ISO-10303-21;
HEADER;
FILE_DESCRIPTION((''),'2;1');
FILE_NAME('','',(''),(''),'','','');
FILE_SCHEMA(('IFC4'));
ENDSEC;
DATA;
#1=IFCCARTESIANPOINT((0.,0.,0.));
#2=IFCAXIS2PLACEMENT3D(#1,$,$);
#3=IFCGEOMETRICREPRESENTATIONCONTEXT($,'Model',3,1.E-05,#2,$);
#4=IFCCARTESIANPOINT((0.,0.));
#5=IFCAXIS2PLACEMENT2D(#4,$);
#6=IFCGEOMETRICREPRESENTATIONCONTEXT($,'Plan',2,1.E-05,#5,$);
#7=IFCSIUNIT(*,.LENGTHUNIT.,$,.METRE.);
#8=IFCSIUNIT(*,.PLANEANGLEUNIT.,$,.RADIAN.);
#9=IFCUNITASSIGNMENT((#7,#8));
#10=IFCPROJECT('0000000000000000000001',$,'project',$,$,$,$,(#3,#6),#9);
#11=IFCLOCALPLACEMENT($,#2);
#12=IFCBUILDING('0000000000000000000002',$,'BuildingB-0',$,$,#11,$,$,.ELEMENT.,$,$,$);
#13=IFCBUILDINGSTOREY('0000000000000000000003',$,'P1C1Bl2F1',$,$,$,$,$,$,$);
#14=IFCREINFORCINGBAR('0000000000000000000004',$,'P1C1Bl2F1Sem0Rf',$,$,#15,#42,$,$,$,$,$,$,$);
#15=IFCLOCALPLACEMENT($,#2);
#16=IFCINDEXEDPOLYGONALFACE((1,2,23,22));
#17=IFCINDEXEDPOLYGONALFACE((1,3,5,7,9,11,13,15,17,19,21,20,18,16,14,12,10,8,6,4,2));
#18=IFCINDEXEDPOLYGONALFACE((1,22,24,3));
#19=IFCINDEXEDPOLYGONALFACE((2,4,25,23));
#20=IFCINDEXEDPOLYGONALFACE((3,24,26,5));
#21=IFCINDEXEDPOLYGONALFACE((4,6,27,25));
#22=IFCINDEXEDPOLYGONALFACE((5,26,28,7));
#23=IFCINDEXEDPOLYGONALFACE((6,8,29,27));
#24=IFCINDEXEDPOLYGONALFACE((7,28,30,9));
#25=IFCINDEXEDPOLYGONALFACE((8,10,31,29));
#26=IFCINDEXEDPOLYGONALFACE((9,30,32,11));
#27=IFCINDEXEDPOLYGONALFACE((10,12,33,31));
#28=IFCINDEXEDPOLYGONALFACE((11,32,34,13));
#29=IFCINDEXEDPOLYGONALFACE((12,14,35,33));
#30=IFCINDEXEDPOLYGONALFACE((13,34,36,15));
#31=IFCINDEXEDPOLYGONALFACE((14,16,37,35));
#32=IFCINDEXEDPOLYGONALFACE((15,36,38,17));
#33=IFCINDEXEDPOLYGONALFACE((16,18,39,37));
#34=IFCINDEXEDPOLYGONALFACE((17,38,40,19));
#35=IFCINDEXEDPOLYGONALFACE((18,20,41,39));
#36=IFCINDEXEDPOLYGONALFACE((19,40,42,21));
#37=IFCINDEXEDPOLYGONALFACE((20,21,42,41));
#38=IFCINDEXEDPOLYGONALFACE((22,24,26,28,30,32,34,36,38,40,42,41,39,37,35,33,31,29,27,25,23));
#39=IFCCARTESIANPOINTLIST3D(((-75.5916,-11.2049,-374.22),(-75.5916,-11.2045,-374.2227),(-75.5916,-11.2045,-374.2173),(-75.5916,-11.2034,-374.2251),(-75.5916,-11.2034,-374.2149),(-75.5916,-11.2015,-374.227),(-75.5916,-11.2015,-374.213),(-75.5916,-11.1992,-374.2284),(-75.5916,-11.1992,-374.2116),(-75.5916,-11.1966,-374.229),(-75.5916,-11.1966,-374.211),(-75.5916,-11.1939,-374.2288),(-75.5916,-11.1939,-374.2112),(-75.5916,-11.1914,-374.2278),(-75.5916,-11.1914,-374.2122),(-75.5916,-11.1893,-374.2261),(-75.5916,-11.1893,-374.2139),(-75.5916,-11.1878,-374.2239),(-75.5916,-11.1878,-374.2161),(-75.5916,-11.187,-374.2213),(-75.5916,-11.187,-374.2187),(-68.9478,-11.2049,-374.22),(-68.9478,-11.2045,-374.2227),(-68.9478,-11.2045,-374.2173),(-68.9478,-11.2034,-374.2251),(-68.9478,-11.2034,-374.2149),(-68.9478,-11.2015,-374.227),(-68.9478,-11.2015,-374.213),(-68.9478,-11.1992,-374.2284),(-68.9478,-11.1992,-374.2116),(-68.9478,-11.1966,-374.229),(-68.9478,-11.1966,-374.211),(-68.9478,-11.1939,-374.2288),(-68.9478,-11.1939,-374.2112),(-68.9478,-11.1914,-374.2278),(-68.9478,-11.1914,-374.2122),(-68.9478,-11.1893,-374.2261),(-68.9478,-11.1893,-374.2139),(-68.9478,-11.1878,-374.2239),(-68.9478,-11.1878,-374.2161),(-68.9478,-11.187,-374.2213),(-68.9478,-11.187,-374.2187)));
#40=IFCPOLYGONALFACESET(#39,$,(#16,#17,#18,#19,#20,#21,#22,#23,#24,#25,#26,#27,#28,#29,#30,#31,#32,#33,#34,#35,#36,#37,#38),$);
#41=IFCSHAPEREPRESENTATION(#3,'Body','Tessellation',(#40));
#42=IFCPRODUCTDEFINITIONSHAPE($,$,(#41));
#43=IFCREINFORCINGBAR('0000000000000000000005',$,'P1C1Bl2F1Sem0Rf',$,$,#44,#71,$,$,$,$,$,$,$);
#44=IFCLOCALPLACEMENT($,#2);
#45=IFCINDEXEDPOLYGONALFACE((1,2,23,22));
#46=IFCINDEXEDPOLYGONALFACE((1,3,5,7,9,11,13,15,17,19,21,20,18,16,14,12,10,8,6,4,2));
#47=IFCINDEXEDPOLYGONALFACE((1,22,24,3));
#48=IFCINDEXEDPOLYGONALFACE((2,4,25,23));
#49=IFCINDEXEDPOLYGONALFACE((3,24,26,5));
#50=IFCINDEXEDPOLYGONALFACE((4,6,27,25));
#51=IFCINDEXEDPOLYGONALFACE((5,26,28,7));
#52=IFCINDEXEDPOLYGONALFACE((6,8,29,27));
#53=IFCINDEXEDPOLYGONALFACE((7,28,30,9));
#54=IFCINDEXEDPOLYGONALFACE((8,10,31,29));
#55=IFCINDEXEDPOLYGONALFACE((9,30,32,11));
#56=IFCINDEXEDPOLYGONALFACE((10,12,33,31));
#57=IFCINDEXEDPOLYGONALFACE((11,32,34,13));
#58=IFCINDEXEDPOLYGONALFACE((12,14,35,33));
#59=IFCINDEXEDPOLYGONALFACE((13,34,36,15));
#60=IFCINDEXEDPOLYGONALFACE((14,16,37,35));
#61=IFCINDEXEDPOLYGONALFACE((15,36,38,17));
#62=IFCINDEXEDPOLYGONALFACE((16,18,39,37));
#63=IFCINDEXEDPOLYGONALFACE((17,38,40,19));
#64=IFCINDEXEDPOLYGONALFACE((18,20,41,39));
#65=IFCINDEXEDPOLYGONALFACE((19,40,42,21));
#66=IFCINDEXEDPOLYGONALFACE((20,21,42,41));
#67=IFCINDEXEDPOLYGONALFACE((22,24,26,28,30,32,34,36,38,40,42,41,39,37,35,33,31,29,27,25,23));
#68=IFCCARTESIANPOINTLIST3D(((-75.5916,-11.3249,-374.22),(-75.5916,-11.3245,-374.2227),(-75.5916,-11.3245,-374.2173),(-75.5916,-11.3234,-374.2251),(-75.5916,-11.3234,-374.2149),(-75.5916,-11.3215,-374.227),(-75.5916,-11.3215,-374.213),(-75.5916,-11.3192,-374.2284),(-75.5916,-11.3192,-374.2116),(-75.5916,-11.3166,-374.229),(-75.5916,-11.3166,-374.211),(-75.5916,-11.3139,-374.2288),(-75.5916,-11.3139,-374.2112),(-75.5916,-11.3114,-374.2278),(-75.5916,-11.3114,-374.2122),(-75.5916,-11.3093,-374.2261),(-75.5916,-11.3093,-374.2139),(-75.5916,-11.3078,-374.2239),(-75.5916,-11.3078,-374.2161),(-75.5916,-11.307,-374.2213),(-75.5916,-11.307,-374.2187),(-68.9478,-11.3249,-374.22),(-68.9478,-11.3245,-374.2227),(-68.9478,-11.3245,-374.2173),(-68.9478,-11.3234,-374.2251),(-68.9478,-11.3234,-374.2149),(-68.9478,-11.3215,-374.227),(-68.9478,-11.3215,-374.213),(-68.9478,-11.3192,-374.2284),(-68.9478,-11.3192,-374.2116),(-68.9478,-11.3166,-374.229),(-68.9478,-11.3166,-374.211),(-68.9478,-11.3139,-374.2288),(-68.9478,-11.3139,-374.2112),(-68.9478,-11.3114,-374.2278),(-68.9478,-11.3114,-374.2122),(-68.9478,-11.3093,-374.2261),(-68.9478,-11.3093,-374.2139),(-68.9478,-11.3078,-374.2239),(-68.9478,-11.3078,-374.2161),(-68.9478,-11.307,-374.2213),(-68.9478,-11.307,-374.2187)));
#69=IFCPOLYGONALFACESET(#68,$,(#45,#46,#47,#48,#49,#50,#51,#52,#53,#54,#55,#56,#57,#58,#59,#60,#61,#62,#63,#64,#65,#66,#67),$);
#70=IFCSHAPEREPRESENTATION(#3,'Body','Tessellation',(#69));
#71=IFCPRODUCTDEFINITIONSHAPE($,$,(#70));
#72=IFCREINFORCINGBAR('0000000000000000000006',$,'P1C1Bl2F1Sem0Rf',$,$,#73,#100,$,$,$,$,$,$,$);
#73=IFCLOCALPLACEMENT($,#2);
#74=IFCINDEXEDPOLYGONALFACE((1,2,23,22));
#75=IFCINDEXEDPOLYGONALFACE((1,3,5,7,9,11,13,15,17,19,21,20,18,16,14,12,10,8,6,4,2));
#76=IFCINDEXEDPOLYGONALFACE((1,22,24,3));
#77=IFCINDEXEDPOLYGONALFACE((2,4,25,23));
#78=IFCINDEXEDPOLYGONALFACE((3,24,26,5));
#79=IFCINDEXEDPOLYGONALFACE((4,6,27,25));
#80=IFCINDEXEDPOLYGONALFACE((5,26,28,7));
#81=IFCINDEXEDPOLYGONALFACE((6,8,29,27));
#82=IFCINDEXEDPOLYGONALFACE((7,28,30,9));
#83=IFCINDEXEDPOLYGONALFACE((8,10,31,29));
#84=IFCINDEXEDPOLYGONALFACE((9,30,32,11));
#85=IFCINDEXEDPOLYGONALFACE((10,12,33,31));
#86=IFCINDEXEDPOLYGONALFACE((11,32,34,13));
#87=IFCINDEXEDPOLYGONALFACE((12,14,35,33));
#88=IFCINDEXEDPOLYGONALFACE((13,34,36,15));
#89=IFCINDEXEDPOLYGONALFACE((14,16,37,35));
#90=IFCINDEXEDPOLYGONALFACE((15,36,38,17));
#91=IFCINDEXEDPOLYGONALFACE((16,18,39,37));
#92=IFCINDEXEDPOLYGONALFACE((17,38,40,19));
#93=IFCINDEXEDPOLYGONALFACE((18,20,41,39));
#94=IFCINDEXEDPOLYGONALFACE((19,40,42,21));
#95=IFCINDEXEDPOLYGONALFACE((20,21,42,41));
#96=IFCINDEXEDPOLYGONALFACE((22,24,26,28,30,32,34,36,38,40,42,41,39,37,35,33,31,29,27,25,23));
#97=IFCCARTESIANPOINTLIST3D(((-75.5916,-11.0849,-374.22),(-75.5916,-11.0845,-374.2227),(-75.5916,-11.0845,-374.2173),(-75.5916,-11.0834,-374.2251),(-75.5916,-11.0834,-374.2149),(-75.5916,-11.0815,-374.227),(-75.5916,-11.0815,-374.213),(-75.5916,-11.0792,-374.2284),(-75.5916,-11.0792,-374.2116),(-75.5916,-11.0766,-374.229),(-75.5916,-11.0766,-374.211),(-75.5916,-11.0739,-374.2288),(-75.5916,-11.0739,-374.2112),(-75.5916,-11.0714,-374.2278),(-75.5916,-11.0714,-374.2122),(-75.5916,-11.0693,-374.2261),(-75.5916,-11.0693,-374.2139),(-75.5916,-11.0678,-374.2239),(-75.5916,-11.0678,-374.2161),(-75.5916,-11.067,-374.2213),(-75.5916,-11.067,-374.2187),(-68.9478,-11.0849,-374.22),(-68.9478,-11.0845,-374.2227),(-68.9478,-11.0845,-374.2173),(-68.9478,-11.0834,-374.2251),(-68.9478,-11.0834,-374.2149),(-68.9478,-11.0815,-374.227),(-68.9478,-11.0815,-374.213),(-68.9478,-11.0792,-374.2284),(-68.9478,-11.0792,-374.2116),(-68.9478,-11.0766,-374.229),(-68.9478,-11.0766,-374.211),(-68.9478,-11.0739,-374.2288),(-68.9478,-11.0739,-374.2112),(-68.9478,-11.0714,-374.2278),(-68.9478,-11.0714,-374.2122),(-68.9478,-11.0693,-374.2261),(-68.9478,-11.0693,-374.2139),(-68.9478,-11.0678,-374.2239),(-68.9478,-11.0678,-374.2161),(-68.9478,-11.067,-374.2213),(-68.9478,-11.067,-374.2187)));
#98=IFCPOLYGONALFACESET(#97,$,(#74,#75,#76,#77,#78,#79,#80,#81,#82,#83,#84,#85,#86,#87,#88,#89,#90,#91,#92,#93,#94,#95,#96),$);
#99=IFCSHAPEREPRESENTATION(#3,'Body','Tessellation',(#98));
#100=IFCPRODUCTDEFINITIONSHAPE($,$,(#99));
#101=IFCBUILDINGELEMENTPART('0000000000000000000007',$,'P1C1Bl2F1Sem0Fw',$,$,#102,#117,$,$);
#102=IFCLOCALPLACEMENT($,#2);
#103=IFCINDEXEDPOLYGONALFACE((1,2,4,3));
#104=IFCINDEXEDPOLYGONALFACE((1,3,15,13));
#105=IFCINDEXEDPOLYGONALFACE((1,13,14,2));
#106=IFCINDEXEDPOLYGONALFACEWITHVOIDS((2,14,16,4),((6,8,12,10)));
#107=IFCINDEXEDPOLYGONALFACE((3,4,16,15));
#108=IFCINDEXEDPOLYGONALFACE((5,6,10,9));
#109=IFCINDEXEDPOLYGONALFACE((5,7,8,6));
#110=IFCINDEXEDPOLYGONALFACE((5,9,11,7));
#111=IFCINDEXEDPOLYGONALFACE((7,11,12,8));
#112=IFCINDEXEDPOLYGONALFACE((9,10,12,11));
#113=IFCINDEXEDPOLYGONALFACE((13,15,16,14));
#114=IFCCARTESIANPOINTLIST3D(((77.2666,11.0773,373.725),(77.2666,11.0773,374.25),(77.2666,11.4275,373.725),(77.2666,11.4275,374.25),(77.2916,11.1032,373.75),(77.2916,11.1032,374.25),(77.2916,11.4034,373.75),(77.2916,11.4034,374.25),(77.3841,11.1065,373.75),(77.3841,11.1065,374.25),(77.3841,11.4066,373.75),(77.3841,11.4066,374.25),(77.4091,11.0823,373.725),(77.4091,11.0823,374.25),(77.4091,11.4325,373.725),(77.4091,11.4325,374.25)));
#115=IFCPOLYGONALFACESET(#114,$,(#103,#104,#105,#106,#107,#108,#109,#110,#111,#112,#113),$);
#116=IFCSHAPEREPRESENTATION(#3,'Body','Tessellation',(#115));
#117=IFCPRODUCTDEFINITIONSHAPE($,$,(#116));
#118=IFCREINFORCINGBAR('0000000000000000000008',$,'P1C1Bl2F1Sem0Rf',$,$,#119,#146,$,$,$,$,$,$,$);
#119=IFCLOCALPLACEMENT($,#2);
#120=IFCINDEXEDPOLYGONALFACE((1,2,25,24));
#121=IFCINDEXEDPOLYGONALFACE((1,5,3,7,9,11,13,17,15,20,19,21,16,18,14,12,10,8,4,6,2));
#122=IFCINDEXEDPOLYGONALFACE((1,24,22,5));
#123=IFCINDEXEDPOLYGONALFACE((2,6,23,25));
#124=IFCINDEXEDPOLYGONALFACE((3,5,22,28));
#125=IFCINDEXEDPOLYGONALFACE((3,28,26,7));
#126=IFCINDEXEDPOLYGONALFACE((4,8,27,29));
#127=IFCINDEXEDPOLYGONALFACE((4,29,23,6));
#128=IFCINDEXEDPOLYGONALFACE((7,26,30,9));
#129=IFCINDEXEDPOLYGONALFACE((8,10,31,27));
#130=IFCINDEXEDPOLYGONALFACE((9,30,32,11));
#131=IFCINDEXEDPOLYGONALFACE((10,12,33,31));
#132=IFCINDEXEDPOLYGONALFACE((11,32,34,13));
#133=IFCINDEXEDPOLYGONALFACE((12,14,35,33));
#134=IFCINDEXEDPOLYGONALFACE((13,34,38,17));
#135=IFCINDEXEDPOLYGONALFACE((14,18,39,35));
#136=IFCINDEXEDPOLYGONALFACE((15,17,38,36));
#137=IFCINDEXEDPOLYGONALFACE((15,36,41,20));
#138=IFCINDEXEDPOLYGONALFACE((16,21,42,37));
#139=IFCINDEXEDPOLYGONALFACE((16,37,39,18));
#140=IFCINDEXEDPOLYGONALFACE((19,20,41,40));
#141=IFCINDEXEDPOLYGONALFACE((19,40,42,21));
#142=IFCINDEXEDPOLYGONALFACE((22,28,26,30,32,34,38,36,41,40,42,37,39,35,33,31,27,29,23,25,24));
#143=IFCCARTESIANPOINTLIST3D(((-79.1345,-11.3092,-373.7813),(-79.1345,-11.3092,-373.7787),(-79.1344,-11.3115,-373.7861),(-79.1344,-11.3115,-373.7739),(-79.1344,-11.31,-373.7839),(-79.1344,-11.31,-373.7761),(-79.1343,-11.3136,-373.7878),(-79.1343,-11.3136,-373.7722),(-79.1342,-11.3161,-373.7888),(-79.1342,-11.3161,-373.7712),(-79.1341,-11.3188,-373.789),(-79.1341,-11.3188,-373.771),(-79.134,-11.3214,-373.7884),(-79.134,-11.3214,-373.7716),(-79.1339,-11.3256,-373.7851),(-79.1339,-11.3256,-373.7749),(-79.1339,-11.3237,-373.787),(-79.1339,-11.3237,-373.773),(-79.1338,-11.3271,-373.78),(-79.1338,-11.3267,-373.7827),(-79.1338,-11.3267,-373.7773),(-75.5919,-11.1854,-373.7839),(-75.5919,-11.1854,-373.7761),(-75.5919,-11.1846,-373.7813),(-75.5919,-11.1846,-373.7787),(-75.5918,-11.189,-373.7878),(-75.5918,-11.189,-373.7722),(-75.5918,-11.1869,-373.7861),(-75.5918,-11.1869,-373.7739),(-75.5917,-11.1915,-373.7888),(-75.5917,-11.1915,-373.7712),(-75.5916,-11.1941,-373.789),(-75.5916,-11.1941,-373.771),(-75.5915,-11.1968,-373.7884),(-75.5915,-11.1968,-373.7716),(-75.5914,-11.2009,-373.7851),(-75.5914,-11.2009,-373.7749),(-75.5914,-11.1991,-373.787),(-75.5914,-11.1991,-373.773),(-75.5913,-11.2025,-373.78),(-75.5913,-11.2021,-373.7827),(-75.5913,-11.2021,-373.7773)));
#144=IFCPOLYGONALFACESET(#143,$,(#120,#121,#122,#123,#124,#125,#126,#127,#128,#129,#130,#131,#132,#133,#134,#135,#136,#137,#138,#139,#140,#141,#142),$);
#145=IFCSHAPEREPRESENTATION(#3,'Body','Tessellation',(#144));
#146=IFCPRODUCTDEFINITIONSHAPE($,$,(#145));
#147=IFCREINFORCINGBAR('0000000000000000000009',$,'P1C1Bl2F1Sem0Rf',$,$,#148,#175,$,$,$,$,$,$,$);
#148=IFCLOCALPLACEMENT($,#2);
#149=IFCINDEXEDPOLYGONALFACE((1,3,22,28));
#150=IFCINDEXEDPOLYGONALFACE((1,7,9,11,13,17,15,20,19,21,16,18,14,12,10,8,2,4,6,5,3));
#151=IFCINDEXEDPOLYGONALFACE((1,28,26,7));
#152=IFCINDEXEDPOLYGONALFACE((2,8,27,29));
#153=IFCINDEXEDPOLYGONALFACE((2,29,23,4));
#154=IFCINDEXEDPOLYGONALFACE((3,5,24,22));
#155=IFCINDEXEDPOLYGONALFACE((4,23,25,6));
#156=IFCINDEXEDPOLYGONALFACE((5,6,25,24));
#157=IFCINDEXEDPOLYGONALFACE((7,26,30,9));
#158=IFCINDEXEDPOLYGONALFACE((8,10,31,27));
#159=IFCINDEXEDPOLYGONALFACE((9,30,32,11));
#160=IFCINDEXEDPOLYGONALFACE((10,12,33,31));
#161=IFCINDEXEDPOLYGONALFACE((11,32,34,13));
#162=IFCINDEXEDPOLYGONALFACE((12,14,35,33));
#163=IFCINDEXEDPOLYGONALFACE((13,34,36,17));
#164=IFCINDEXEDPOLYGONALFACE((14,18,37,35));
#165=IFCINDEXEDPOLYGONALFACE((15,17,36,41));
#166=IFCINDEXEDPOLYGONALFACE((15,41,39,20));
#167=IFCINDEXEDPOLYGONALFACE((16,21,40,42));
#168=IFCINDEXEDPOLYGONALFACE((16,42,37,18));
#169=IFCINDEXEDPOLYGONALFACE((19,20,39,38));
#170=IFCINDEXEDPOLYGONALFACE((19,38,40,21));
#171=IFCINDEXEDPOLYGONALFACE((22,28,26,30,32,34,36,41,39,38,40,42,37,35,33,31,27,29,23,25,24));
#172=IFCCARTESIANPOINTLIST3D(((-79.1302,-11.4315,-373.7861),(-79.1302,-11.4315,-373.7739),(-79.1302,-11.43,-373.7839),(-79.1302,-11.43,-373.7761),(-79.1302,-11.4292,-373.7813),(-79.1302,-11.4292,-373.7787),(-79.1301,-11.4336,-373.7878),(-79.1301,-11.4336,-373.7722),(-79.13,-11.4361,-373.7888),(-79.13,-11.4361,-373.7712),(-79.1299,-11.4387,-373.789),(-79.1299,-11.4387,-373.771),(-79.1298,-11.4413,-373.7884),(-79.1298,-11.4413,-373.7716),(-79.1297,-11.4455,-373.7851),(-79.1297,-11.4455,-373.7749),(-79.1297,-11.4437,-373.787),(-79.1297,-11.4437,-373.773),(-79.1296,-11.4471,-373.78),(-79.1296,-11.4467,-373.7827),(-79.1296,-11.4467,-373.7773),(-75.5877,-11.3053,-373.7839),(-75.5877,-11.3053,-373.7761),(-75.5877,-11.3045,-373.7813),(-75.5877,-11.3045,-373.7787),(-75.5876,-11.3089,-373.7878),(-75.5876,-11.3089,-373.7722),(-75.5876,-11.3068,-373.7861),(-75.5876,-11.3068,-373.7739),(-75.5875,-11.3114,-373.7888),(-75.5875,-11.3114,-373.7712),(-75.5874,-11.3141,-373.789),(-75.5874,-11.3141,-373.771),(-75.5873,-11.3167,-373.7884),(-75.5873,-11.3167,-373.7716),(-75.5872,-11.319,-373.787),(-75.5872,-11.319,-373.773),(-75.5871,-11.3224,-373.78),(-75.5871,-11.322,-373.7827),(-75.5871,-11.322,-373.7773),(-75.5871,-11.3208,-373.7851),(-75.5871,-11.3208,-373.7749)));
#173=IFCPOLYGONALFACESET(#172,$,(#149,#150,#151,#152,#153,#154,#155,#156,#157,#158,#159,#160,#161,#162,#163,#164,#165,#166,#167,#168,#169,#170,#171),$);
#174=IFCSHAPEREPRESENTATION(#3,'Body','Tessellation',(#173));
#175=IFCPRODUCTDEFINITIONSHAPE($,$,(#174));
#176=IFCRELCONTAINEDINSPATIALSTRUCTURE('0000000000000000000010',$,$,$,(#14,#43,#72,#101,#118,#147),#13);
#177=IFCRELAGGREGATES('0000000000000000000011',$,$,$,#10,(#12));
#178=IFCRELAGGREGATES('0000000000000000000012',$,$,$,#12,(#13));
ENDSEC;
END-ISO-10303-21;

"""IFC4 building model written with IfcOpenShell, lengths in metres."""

from ifc_helpers import new_model, entity, si_unit, origin, origin_2d, place, context, project, spatial, polyline, outline, extrude, element, save


model = new_model("IFC4")

# Units and contexts
model_context = context("Model", 3, precision=1e-05, world=origin())
plan_context = context("Plan", 2, precision=1e-05, world=origin_2d())
ifc_project = project(units=[si_unit("LENGTHUNIT", "METRE"), si_unit("PLANEANGLEUNIT", "RADIAN")], contexts=[model_context, plan_context])

# Building, storey
building_placement = place(None, origin())
building = spatial("IfcBuilding", under=ifc_project, at=building_placement, Name="BuildingB-0", CompositionType="ELEMENT")
storey = spatial("IfcBuildingStorey", under=building, Name="P1C1Bl2F1")

# Reinforcing bars
element("IfcReinforcingBar", 1, inside=storey, Name="P1C1Bl2F1Sem0Rf", context=model_context, shape_type="SweptSolid", body=[
    entity("IfcSurfaceCurveSweptAreaSolid", entity("IfcCircleProfileDef", "AREA", None, None, 0.009), None, entity("IfcPolyline", [entity("IfcCartesianPoint", [75.5916, 11.1959, 374.22]), entity("IfcCartesianPoint", [68.9478, 11.1959, 374.22])]), None, None, entity("IfcPlane", entity("IfcAxis2Placement3D", entity("IfcCartesianPoint", [75.5916, 11.1959, 374.22]), entity("IfcDirection", [0.0, 0.0, 1.0]), entity("IfcDirection", [1.0, 0.0, 0.0])))),
])
element("IfcReinforcingBar", 2, inside=storey, Name="P1C1Bl2F1Sem0Rf", context=model_context, shape_type="SweptSolid", body=[
    entity("IfcSurfaceCurveSweptAreaSolid", entity("IfcCircleProfileDef", "AREA", None, None, 0.009), None, entity("IfcPolyline", [entity("IfcCartesianPoint", [75.5916, 11.3159, 374.22]), entity("IfcCartesianPoint", [68.9478, 11.3159, 374.22])]), None, None, entity("IfcPlane", entity("IfcAxis2Placement3D", entity("IfcCartesianPoint", [75.5916, 11.3159, 374.22]), entity("IfcDirection", [0.0, 0.0, 1.0]), entity("IfcDirection", [1.0, 0.0, 0.0])))),
])
element("IfcReinforcingBar", 3, inside=storey, Name="P1C1Bl2F1Sem0Rf", context=model_context, shape_type="SweptSolid", body=[
    entity("IfcSurfaceCurveSweptAreaSolid", entity("IfcCircleProfileDef", "AREA", None, None, 0.009), None, entity("IfcPolyline", [entity("IfcCartesianPoint", [75.5916, 11.0759, 374.22]), entity("IfcCartesianPoint", [68.9478, 11.0759, 374.22])]), None, None, entity("IfcPlane", entity("IfcAxis2Placement3D", entity("IfcCartesianPoint", [75.5916, 11.0759, 374.22]), entity("IfcDirection", [0.0, 0.0, 1.0]), entity("IfcDirection", [1.0, 0.0, 0.0])))),
])

# Building element part, opening
building_element_part_1 = element("IfcBuildingElementPart", 4, inside=storey, Name="P1C1Bl2F1Sem0Fw", context=model_context, shape_type="SweptSolid", body=[
    extrude(outline(polyline([(77.4091, 11.0823, 373.725), (77.2666, 11.0773, 373.725), (77.2666, 11.4275, 373.725), (77.4091, 11.4325, 373.725), (77.4091, 11.0823, 373.725)])), None, (0.0, 0.0, 1.0), 0.525),
])
element("IfcOpeningElement", 5, inside=storey, cuts=building_element_part_1, context=model_context, shape_type="SweptSolid", body=[
    extrude(outline(polyline([(77.3841, 11.1065, 373.75), (77.2916, 11.1032, 373.75), (77.2916, 11.4034, 373.75), (77.3841, 11.4066, 373.75), (77.3841, 11.1065, 373.75)])), None, (0.0, 0.0, 1.0), 0.5),
])

# Reinforcing bars
element("IfcReinforcingBar", 6, inside=storey, Name="P1C1Bl2F1Sem0Rf", context=model_context, shape_type="SweptSolid", body=[
    entity("IfcSurfaceCurveSweptAreaSolid", entity("IfcCircleProfileDef", "AREA", None, None, 0.009), None, entity("IfcPolyline", [entity("IfcCartesianPoint", [79.1341, 11.3181, 373.78]), entity("IfcCartesianPoint", [75.5916, 11.1935, 373.78])]), None, None, entity("IfcPlane", entity("IfcAxis2Placement3D", entity("IfcCartesianPoint", [79.1341, 11.3181, 373.78]), entity("IfcDirection", [0.0, 0.0, 1.0]), entity("IfcDirection", [1.0, 0.0, 0.0])))),
])
element("IfcReinforcingBar", 7, inside=storey, Name="P1C1Bl2F1Sem0Rf", context=model_context, shape_type="SweptSolid", body=[
    entity("IfcSurfaceCurveSweptAreaSolid", entity("IfcCircleProfileDef", "AREA", None, None, 0.009), None, entity("IfcPolyline", [entity("IfcCartesianPoint", [79.1299, 11.4381, 373.78]), entity("IfcCartesianPoint", [75.5874, 11.3134, 373.78])]), None, None, entity("IfcPlane", entity("IfcAxis2Placement3D", entity("IfcCartesianPoint", [79.1299, 11.4381, 373.78]), entity("IfcDirection", [0.0, 0.0, 1.0]), entity("IfcDirection", [1.0, 0.0, 0.0])))),
])

save(model, "model.ifc")
